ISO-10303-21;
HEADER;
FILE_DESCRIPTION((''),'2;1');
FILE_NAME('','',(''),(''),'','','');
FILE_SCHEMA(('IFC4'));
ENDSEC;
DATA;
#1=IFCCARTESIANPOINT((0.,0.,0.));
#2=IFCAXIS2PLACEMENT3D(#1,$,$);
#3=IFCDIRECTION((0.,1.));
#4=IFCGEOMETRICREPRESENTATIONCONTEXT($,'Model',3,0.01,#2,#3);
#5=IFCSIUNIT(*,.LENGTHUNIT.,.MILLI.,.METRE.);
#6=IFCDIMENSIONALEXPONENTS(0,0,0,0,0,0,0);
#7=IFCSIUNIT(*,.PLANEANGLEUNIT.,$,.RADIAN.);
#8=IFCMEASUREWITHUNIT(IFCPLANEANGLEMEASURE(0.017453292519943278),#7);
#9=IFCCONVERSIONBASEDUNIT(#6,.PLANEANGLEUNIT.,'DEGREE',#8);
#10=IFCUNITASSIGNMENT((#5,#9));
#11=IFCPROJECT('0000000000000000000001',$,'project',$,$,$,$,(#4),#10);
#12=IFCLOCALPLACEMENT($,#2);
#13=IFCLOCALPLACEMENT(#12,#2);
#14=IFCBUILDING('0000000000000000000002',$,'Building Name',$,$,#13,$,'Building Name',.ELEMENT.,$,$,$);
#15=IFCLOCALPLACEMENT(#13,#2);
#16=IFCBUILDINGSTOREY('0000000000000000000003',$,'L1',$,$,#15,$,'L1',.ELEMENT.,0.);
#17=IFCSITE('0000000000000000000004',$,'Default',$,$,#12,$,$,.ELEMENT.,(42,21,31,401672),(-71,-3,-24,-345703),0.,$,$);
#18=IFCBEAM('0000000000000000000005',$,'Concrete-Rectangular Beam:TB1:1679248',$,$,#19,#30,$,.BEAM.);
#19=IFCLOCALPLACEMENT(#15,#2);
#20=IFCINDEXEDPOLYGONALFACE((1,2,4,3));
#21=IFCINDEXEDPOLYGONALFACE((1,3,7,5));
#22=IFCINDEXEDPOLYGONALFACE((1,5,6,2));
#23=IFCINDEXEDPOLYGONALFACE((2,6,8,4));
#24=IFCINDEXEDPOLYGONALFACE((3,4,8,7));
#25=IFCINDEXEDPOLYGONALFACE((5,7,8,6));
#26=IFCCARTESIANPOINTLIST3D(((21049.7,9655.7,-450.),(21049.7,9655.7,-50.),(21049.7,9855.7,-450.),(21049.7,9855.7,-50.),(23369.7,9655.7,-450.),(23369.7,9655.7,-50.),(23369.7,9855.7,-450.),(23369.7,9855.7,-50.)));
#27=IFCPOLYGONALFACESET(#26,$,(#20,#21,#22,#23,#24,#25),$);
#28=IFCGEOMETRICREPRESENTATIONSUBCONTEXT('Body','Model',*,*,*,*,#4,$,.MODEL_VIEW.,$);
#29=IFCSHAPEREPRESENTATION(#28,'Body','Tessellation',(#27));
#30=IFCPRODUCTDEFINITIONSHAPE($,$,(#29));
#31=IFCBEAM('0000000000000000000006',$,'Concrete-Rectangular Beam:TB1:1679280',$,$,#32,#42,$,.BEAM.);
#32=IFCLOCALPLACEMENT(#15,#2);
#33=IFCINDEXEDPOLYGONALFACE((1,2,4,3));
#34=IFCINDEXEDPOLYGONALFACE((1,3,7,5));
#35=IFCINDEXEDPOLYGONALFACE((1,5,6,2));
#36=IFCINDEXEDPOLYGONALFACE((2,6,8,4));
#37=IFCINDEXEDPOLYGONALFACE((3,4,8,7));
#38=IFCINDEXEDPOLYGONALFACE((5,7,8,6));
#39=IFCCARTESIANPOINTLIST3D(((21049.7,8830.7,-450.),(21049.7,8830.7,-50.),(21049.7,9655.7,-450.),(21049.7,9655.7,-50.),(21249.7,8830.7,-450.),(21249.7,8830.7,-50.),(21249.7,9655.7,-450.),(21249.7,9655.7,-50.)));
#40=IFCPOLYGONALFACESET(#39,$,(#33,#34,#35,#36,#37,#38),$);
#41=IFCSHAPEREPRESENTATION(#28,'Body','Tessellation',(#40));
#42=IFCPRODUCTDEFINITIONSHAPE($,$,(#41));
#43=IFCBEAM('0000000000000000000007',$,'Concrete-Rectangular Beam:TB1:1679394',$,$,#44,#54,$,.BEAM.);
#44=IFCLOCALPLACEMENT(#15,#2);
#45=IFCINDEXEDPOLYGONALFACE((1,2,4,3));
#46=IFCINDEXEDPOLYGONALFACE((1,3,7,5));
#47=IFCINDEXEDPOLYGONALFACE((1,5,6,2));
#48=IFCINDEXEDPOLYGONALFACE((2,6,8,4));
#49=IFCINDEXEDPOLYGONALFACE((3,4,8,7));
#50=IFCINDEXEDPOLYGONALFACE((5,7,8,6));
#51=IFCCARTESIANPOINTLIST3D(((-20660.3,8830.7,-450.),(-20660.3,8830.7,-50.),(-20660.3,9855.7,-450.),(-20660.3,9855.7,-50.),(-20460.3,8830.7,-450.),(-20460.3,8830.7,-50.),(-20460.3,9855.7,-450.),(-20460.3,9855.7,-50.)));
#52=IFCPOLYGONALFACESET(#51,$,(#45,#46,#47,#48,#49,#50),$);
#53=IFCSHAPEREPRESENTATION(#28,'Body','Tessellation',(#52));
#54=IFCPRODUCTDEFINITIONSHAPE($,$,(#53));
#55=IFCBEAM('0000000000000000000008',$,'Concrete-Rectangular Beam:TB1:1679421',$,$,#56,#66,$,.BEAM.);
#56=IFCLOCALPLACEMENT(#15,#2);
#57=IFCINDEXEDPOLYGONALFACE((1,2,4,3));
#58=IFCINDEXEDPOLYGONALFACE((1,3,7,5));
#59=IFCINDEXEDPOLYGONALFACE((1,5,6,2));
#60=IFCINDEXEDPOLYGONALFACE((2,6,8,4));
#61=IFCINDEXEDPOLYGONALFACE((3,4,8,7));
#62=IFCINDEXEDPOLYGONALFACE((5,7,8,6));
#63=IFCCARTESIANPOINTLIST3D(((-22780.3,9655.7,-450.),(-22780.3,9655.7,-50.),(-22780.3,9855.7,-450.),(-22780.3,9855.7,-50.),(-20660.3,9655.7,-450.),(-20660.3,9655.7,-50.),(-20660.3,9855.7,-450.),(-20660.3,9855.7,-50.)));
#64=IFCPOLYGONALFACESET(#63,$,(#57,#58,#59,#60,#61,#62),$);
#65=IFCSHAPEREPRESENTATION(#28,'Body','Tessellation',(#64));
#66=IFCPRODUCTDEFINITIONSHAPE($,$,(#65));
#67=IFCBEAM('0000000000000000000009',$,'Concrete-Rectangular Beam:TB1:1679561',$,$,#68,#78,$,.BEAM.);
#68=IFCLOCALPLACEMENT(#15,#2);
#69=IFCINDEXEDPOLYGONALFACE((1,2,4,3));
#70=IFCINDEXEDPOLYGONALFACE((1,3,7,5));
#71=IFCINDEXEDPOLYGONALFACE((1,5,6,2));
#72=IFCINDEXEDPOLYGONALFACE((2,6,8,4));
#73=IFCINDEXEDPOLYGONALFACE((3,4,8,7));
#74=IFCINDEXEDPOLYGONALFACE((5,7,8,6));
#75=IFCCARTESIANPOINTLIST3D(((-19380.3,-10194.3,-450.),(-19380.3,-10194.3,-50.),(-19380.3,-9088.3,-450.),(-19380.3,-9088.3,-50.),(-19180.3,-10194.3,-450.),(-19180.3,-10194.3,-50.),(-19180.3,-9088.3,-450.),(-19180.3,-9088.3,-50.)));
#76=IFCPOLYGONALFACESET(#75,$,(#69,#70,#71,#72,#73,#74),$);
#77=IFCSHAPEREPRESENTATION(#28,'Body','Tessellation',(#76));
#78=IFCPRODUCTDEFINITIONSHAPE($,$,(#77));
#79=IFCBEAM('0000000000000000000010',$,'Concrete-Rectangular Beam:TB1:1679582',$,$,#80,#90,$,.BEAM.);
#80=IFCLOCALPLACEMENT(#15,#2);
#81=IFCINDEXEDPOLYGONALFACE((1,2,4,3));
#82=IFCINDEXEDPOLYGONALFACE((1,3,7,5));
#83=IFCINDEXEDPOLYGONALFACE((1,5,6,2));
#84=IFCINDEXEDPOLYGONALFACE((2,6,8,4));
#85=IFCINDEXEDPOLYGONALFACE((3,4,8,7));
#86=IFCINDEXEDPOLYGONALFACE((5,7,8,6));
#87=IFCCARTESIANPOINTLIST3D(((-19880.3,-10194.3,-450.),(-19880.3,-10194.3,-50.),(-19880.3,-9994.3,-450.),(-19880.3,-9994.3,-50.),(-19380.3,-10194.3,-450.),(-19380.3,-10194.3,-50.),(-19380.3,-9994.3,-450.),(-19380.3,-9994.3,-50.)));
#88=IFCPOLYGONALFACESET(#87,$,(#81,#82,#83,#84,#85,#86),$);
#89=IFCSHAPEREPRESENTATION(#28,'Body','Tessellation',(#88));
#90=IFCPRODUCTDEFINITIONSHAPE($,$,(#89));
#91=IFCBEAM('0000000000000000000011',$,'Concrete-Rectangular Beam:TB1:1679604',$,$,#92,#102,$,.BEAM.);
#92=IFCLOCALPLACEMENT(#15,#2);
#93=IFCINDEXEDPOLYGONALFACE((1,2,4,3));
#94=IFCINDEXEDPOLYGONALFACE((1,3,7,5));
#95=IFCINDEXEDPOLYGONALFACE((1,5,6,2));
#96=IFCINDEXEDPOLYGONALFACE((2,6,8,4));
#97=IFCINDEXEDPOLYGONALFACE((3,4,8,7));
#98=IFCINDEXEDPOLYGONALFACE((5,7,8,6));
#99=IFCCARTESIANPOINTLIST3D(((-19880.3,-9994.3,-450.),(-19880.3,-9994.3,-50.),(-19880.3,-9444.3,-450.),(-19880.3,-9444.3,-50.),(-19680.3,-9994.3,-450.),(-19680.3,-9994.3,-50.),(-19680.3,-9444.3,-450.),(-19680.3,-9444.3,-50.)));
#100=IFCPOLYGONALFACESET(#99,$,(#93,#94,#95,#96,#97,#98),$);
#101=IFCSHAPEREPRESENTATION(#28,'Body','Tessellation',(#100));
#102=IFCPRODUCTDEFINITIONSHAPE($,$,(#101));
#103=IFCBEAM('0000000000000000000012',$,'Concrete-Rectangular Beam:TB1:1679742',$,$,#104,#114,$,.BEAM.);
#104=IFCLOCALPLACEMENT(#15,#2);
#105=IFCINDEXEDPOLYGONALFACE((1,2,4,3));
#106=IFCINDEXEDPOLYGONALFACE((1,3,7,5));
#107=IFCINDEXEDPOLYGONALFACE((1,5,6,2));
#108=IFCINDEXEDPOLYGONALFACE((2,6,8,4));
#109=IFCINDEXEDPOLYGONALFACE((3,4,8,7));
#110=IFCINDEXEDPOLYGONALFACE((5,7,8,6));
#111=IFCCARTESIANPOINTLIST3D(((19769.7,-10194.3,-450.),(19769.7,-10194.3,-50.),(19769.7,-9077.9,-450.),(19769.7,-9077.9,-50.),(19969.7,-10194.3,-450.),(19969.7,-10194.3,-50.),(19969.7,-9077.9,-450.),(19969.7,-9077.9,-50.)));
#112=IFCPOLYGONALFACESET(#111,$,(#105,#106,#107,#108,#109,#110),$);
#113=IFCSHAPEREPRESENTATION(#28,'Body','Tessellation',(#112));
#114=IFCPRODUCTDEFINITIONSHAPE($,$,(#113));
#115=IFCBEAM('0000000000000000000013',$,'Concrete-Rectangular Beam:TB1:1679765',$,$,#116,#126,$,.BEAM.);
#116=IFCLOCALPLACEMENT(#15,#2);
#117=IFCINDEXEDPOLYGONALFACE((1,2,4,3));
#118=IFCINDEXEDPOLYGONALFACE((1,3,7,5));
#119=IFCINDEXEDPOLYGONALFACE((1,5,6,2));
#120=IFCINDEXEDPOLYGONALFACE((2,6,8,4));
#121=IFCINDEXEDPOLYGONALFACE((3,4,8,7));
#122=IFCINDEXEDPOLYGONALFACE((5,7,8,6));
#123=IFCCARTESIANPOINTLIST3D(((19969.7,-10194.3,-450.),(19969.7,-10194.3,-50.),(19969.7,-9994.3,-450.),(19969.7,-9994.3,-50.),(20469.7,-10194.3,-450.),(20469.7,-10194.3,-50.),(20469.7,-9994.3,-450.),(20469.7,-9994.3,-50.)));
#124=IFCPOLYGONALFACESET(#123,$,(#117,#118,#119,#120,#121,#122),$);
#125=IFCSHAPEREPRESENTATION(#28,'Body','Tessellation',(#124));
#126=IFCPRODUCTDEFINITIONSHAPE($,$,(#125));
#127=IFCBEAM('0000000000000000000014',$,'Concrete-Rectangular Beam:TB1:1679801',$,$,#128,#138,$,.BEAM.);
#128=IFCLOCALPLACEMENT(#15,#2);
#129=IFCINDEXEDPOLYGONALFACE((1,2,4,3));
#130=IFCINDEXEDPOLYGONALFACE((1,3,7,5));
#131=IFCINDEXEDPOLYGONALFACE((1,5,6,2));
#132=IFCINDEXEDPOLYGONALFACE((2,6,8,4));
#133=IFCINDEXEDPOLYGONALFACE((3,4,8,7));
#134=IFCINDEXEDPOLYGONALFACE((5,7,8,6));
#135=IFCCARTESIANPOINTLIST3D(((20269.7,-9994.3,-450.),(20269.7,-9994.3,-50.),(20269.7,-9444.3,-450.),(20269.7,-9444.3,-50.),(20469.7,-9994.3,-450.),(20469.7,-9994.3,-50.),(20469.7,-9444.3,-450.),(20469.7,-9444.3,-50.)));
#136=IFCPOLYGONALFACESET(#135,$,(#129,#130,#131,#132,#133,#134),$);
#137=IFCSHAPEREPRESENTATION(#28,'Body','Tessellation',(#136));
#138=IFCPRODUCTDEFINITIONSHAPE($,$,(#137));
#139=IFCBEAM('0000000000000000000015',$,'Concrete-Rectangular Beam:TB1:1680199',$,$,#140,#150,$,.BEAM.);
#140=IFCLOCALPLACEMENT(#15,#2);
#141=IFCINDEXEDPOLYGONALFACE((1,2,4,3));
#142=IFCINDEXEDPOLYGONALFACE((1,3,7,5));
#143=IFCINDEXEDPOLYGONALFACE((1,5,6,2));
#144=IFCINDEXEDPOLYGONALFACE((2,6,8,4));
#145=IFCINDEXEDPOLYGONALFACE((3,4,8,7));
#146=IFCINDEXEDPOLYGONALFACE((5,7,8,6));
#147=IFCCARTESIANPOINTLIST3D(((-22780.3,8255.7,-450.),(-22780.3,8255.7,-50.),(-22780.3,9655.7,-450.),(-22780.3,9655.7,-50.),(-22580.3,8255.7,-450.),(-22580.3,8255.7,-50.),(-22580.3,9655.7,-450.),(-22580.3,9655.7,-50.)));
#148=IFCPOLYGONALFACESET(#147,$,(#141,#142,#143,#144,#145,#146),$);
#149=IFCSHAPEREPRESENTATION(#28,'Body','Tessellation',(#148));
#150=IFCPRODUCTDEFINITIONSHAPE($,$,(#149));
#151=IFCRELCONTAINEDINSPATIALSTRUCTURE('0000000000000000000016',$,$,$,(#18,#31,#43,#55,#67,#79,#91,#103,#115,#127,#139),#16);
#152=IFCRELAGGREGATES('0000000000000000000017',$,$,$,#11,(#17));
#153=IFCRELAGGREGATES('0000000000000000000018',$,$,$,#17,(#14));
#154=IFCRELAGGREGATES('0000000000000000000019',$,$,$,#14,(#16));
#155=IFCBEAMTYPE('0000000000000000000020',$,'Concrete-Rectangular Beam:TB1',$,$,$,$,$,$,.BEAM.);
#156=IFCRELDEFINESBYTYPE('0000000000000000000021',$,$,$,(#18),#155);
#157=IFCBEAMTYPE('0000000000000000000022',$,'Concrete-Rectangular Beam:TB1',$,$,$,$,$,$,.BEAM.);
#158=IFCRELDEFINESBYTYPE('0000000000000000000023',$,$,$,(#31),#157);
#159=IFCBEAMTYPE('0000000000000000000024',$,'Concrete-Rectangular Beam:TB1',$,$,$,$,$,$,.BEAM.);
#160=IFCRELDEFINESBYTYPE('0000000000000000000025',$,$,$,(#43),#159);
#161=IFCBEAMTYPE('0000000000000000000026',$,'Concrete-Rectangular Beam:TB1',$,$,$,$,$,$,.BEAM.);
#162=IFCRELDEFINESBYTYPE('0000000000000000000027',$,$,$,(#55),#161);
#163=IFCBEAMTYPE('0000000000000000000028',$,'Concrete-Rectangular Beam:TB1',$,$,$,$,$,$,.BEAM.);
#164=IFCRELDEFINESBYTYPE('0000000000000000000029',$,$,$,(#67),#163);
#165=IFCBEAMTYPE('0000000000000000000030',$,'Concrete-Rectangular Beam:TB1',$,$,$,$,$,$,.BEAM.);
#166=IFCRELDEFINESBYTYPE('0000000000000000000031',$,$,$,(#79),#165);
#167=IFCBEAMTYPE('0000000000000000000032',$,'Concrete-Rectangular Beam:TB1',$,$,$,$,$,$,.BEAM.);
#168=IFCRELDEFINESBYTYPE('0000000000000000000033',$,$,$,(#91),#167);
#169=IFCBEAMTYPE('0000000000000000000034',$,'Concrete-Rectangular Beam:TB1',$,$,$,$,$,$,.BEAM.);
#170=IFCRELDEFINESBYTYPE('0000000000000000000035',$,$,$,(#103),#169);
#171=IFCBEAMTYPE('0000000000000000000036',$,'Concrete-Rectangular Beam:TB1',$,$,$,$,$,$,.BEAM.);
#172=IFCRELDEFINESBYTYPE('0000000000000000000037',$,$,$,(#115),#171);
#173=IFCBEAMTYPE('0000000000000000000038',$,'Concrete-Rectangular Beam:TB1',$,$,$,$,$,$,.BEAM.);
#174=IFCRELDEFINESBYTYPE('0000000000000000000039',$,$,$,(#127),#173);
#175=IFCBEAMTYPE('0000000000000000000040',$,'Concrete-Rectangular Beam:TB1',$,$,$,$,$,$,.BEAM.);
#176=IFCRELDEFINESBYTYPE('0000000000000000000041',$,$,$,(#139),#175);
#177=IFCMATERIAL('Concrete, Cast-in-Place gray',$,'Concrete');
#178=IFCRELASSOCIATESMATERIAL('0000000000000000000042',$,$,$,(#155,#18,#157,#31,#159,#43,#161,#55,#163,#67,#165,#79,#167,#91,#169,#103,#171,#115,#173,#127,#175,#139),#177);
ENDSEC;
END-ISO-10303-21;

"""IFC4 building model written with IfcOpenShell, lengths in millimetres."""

from ifc_helpers import new_model, entity, si_unit, converted_unit, direction, frame, origin, place, context, subcontext, project, spatial, indexed_curve, outline, extrude, source, transform, mapped, material, type_object, type_shapes, element, save


model = new_model("IFC4")

# Units and contexts
model_context = context("Model", 3, precision=0.01, world=origin(), true_north=direction((0.0, 1.0)))
body_context = subcontext(model_context, "Body", "Model", "MODEL_VIEW")
ifc_project = project(units=[si_unit("LENGTHUNIT", "METRE", prefix="MILLI"), converted_unit("PLANEANGLEUNIT", "DEGREE", entity("IfcPlaneAngleMeasure", 0.017453292519943278), si_unit("PLANEANGLEUNIT", "RADIAN"), dimensions=[0, 0, 0, 0, 0, 0, 0])], contexts=[model_context])

# Site, building, storey
site_placement = place(None, origin())
site = spatial("IfcSite", under=ifc_project, at=site_placement, Name="Default", CompositionType="ELEMENT", RefLatitude=(42, 21, 31, 401672), RefLongitude=(-71, -3, -24, -345703), RefElevation=0.0)
building_placement = place(site_placement, origin())
building = spatial("IfcBuilding", under=site, at=building_placement, Name="Building Name", LongName="Building Name", CompositionType="ELEMENT")
storey_placement = place(building_placement, origin())
storey = spatial("IfcBuildingStorey", under=building, at=storey_placement, Name="L1", LongName="L1", CompositionType="ELEMENT", Elevation=0.0)

# Shared definitions
ifc_material = material(Name="Concrete, Cast-in-Place gray", Category="Concrete")

# Beams
beam_type_1 = type_object("IfcBeamType", Name="Concrete-Rectangular Beam:TB1", PredefinedType="BEAM", material=ifc_material)
shared_shape_1 = source(origin(), body_context, "Body", "SweptSolid", [
    extrude(outline(indexed_curve([(-200.0, -100.0), (200.0, -100.0), (200.0, 100.0), (-200.0, 100.0), (-200.0, -100.0)], self_intersect=False)), frame((23369.7, 9755.7, -250.0), z_axis=(-1.0, 0.0, 0.0), x_axis=(0.0, 0.0, -1.0)), (0.0, 0.0, 1.0), 2320.0),
])
type_shapes(beam_type_1, [shared_shape_1])
beam_1_placement = place(storey_placement, origin())
element("IfcBeam", 1, at=beam_1_placement, inside=storey, type_object=beam_type_1, material=ifc_material, Name="Concrete-Rectangular Beam:TB1:1679248", PredefinedType="BEAM", context=body_context, shape_type="MappedRepresentation", body=[
    mapped(shared_shape_1, transform((0.0, 0.0, 0.0), scale=1.0)),
])
beam_type_2 = type_object("IfcBeamType", Name="Concrete-Rectangular Beam:TB1", PredefinedType="BEAM", material=ifc_material)
shared_shape_2 = source(origin(), body_context, "Body", "SweptSolid", [
    extrude(outline(indexed_curve([(-100.0, -200.0), (100.0, -200.0), (100.0, 200.0), (-100.0, 200.0), (-100.0, -200.0)], self_intersect=False)), frame((21149.7, 8830.7, -250.0), z_axis=(0.0, 1.0, 0.0), x_axis=(-1.0, 0.0, 0.0)), (0.0, 0.0, 1.0), 825.0),
])
type_shapes(beam_type_2, [shared_shape_2])
beam_2_placement = place(storey_placement, origin())
element("IfcBeam", 2, at=beam_2_placement, inside=storey, type_object=beam_type_2, material=ifc_material, Name="Concrete-Rectangular Beam:TB1:1679280", PredefinedType="BEAM", context=body_context, shape_type="MappedRepresentation", body=[
    mapped(shared_shape_2, transform((0.0, 0.0, 0.0), scale=1.0)),
])
beam_type_3 = type_object("IfcBeamType", Name="Concrete-Rectangular Beam:TB1", PredefinedType="BEAM", material=ifc_material)
shared_shape_3 = source(origin(), body_context, "Body", "SweptSolid", [
    extrude(outline(indexed_curve([(-100.0, -200.0), (100.0, -200.0), (100.0, 200.0), (-100.0, 200.0), (-100.0, -200.0)], self_intersect=False)), frame((-20560.3, 8830.7, -250.0), z_axis=(0.0, 1.0, 0.0), x_axis=(-1.0, 0.0, 0.0)), (0.0, 0.0, 1.0), 1025.0),
])
type_shapes(beam_type_3, [shared_shape_3])
beam_3_placement = place(storey_placement, origin())
element("IfcBeam", 3, at=beam_3_placement, inside=storey, type_object=beam_type_3, material=ifc_material, Name="Concrete-Rectangular Beam:TB1:1679394", PredefinedType="BEAM", context=body_context, shape_type="MappedRepresentation", body=[
    mapped(shared_shape_3, transform((0.0, 0.0, 0.0), scale=1.0)),
])
beam_type_4 = type_object("IfcBeamType", Name="Concrete-Rectangular Beam:TB1", PredefinedType="BEAM", material=ifc_material)
shared_shape_4 = source(origin(), body_context, "Body", "SweptSolid", [
    extrude(outline(indexed_curve([(-200.0, -100.0), (200.0, -100.0), (200.0, 100.0), (-200.0, 100.0), (-200.0, -100.0)], self_intersect=False)), frame((-20660.3, 9755.7, -250.0), z_axis=(-1.0, 0.0, 0.0), x_axis=(0.0, 0.0, -1.0)), (0.0, 0.0, 1.0), 2120.0),
])
type_shapes(beam_type_4, [shared_shape_4])
beam_4_placement = place(storey_placement, origin())
element("IfcBeam", 4, at=beam_4_placement, inside=storey, type_object=beam_type_4, material=ifc_material, Name="Concrete-Rectangular Beam:TB1:1679421", PredefinedType="BEAM", context=body_context, shape_type="MappedRepresentation", body=[
    mapped(shared_shape_4, transform((0.0, 0.0, 0.0), scale=1.0)),
])
beam_type_5 = type_object("IfcBeamType", Name="Concrete-Rectangular Beam:TB1", PredefinedType="BEAM", material=ifc_material)
shared_shape_5 = source(origin(), body_context, "Body", "SweptSolid", [
    extrude(outline(indexed_curve([(-100.0, -200.0), (100.0, -200.0), (100.0, 200.0), (-100.0, 200.0), (-100.0, -200.0)], self_intersect=False)), frame((-19280.3, -9088.3, -250.0), z_axis=(0.0, -1.0, 0.0), x_axis=(-1.0, 0.0, 0.0)), (0.0, 0.0, 1.0), 1106.0),
])
type_shapes(beam_type_5, [shared_shape_5])
beam_5_placement = place(storey_placement, origin())
element("IfcBeam", 5, at=beam_5_placement, inside=storey, type_object=beam_type_5, material=ifc_material, Name="Concrete-Rectangular Beam:TB1:1679561", PredefinedType="BEAM", context=body_context, shape_type="MappedRepresentation", body=[
    mapped(shared_shape_5, transform((0.0, 0.0, 0.0), scale=1.0)),
])
beam_type_6 = type_object("IfcBeamType", Name="Concrete-Rectangular Beam:TB1", PredefinedType="BEAM", material=ifc_material)
shared_shape_6 = source(origin(), body_context, "Body", "SweptSolid", [
    extrude(outline(indexed_curve([(-200.0, -100.0), (200.0, -100.0), (200.0, 100.0), (-200.0, 100.0), (-200.0, -100.0)], self_intersect=False)), frame((-19380.3, -10094.3, -250.0), z_axis=(-1.0, 0.0, 0.0), x_axis=(0.0, 0.0, -1.0)), (0.0, 0.0, 1.0), 500.0),
])
type_shapes(beam_type_6, [shared_shape_6])
beam_6_placement = place(storey_placement, origin())
element("IfcBeam", 6, at=beam_6_placement, inside=storey, type_object=beam_type_6, material=ifc_material, Name="Concrete-Rectangular Beam:TB1:1679582", PredefinedType="BEAM", context=body_context, shape_type="MappedRepresentation", body=[
    mapped(shared_shape_6, transform((0.0, 0.0, 0.0), scale=1.0)),
])
beam_type_7 = type_object("IfcBeamType", Name="Concrete-Rectangular Beam:TB1", PredefinedType="BEAM", material=ifc_material)
shared_shape_7 = source(origin(), body_context, "Body", "SweptSolid", [
    extrude(outline(indexed_curve([(-100.0, -200.0), (100.0, -200.0), (100.0, 200.0), (-100.0, 200.0), (-100.0, -200.0)], self_intersect=False)), frame((-19780.3, -9994.3, -250.0), z_axis=(0.0, 1.0, 0.0), x_axis=(-1.0, 0.0, 0.0)), (0.0, 0.0, 1.0), 550.0),
])
type_shapes(beam_type_7, [shared_shape_7])
beam_7_placement = place(storey_placement, origin())
element("IfcBeam", 7, at=beam_7_placement, inside=storey, type_object=beam_type_7, material=ifc_material, Name="Concrete-Rectangular Beam:TB1:1679604", PredefinedType="BEAM", context=body_context, shape_type="MappedRepresentation", body=[
    mapped(shared_shape_7, transform((0.0, 0.0, 0.0), scale=1.0)),
])
beam_type_8 = type_object("IfcBeamType", Name="Concrete-Rectangular Beam:TB1", PredefinedType="BEAM", material=ifc_material)
shared_shape_8 = source(origin(), body_context, "Body", "SweptSolid", [
    extrude(outline(indexed_curve([(-100.0, -200.0), (100.0, -200.0), (100.0, 200.0), (-100.0, 200.0), (-100.0, -200.0)], self_intersect=False)), frame((19869.7, -9077.9, -250.0), z_axis=(0.0, -1.0, 0.0), x_axis=(-1.0, 0.0, 0.0)), (0.0, 0.0, 1.0), 1116.4),
])
type_shapes(beam_type_8, [shared_shape_8])
beam_8_placement = place(storey_placement, origin())
element("IfcBeam", 8, at=beam_8_placement, inside=storey, type_object=beam_type_8, material=ifc_material, Name="Concrete-Rectangular Beam:TB1:1679742", PredefinedType="BEAM", context=body_context, shape_type="MappedRepresentation", body=[
    mapped(shared_shape_8, transform((0.0, 0.0, 0.0), scale=1.0)),
])
beam_type_9 = type_object("IfcBeamType", Name="Concrete-Rectangular Beam:TB1", PredefinedType="BEAM", material=ifc_material)
shared_shape_9 = source(origin(), body_context, "Body", "SweptSolid", [
    extrude(outline(indexed_curve([(-200.0, -100.0), (200.0, -100.0), (200.0, 100.0), (-200.0, 100.0), (-200.0, -100.0)], self_intersect=False)), frame((19969.7, -10094.3, -250.0), z_axis=(1.0, 0.0, 0.0), x_axis=(0.0, 0.0, -1.0)), (0.0, 0.0, 1.0), 500.0),
])
type_shapes(beam_type_9, [shared_shape_9])
beam_9_placement = place(storey_placement, origin())
element("IfcBeam", 9, at=beam_9_placement, inside=storey, type_object=beam_type_9, material=ifc_material, Name="Concrete-Rectangular Beam:TB1:1679765", PredefinedType="BEAM", context=body_context, shape_type="MappedRepresentation", body=[
    mapped(shared_shape_9, transform((0.0, 0.0, 0.0), scale=1.0)),
])
beam_type_10 = type_object("IfcBeamType", Name="Concrete-Rectangular Beam:TB1", PredefinedType="BEAM", material=ifc_material)
shared_shape_10 = source(origin(), body_context, "Body", "SweptSolid", [
    extrude(outline(indexed_curve([(-100.0, -200.0), (100.0, -200.0), (100.0, 200.0), (-100.0, 200.0), (-100.0, -200.0)], self_intersect=False)), frame((20369.7, -9994.3, -250.0), z_axis=(0.0, 1.0, 0.0), x_axis=(-1.0, 0.0, 0.0)), (0.0, 0.0, 1.0), 550.0),
])
type_shapes(beam_type_10, [shared_shape_10])
beam_10_placement = place(storey_placement, origin())
element("IfcBeam", 10, at=beam_10_placement, inside=storey, type_object=beam_type_10, material=ifc_material, Name="Concrete-Rectangular Beam:TB1:1679801", PredefinedType="BEAM", context=body_context, shape_type="MappedRepresentation", body=[
    mapped(shared_shape_10, transform((0.0, 0.0, 0.0), scale=1.0)),
])
beam_type_11 = type_object("IfcBeamType", Name="Concrete-Rectangular Beam:TB1", PredefinedType="BEAM", material=ifc_material)
shared_shape_11 = source(origin(), body_context, "Body", "SweptSolid", [
    extrude(outline(indexed_curve([(-100.0, -200.0), (100.0, -200.0), (100.0, 200.0), (-100.0, 200.0), (-100.0, -200.0)], self_intersect=False)), frame((-22680.3, 9655.7, -250.0), z_axis=(0.0, -1.0, 0.0), x_axis=(-1.0, 0.0, 0.0)), (0.0, 0.0, 1.0), 1400.0),
])
type_shapes(beam_type_11, [shared_shape_11])
beam_11_placement = place(storey_placement, origin())
element("IfcBeam", 11, at=beam_11_placement, inside=storey, type_object=beam_type_11, material=ifc_material, Name="Concrete-Rectangular Beam:TB1:1680199", PredefinedType="BEAM", context=body_context, shape_type="MappedRepresentation", body=[
    mapped(shared_shape_11, transform((0.0, 0.0, 0.0), scale=1.0)),
])

save(model, "model.ifc")
